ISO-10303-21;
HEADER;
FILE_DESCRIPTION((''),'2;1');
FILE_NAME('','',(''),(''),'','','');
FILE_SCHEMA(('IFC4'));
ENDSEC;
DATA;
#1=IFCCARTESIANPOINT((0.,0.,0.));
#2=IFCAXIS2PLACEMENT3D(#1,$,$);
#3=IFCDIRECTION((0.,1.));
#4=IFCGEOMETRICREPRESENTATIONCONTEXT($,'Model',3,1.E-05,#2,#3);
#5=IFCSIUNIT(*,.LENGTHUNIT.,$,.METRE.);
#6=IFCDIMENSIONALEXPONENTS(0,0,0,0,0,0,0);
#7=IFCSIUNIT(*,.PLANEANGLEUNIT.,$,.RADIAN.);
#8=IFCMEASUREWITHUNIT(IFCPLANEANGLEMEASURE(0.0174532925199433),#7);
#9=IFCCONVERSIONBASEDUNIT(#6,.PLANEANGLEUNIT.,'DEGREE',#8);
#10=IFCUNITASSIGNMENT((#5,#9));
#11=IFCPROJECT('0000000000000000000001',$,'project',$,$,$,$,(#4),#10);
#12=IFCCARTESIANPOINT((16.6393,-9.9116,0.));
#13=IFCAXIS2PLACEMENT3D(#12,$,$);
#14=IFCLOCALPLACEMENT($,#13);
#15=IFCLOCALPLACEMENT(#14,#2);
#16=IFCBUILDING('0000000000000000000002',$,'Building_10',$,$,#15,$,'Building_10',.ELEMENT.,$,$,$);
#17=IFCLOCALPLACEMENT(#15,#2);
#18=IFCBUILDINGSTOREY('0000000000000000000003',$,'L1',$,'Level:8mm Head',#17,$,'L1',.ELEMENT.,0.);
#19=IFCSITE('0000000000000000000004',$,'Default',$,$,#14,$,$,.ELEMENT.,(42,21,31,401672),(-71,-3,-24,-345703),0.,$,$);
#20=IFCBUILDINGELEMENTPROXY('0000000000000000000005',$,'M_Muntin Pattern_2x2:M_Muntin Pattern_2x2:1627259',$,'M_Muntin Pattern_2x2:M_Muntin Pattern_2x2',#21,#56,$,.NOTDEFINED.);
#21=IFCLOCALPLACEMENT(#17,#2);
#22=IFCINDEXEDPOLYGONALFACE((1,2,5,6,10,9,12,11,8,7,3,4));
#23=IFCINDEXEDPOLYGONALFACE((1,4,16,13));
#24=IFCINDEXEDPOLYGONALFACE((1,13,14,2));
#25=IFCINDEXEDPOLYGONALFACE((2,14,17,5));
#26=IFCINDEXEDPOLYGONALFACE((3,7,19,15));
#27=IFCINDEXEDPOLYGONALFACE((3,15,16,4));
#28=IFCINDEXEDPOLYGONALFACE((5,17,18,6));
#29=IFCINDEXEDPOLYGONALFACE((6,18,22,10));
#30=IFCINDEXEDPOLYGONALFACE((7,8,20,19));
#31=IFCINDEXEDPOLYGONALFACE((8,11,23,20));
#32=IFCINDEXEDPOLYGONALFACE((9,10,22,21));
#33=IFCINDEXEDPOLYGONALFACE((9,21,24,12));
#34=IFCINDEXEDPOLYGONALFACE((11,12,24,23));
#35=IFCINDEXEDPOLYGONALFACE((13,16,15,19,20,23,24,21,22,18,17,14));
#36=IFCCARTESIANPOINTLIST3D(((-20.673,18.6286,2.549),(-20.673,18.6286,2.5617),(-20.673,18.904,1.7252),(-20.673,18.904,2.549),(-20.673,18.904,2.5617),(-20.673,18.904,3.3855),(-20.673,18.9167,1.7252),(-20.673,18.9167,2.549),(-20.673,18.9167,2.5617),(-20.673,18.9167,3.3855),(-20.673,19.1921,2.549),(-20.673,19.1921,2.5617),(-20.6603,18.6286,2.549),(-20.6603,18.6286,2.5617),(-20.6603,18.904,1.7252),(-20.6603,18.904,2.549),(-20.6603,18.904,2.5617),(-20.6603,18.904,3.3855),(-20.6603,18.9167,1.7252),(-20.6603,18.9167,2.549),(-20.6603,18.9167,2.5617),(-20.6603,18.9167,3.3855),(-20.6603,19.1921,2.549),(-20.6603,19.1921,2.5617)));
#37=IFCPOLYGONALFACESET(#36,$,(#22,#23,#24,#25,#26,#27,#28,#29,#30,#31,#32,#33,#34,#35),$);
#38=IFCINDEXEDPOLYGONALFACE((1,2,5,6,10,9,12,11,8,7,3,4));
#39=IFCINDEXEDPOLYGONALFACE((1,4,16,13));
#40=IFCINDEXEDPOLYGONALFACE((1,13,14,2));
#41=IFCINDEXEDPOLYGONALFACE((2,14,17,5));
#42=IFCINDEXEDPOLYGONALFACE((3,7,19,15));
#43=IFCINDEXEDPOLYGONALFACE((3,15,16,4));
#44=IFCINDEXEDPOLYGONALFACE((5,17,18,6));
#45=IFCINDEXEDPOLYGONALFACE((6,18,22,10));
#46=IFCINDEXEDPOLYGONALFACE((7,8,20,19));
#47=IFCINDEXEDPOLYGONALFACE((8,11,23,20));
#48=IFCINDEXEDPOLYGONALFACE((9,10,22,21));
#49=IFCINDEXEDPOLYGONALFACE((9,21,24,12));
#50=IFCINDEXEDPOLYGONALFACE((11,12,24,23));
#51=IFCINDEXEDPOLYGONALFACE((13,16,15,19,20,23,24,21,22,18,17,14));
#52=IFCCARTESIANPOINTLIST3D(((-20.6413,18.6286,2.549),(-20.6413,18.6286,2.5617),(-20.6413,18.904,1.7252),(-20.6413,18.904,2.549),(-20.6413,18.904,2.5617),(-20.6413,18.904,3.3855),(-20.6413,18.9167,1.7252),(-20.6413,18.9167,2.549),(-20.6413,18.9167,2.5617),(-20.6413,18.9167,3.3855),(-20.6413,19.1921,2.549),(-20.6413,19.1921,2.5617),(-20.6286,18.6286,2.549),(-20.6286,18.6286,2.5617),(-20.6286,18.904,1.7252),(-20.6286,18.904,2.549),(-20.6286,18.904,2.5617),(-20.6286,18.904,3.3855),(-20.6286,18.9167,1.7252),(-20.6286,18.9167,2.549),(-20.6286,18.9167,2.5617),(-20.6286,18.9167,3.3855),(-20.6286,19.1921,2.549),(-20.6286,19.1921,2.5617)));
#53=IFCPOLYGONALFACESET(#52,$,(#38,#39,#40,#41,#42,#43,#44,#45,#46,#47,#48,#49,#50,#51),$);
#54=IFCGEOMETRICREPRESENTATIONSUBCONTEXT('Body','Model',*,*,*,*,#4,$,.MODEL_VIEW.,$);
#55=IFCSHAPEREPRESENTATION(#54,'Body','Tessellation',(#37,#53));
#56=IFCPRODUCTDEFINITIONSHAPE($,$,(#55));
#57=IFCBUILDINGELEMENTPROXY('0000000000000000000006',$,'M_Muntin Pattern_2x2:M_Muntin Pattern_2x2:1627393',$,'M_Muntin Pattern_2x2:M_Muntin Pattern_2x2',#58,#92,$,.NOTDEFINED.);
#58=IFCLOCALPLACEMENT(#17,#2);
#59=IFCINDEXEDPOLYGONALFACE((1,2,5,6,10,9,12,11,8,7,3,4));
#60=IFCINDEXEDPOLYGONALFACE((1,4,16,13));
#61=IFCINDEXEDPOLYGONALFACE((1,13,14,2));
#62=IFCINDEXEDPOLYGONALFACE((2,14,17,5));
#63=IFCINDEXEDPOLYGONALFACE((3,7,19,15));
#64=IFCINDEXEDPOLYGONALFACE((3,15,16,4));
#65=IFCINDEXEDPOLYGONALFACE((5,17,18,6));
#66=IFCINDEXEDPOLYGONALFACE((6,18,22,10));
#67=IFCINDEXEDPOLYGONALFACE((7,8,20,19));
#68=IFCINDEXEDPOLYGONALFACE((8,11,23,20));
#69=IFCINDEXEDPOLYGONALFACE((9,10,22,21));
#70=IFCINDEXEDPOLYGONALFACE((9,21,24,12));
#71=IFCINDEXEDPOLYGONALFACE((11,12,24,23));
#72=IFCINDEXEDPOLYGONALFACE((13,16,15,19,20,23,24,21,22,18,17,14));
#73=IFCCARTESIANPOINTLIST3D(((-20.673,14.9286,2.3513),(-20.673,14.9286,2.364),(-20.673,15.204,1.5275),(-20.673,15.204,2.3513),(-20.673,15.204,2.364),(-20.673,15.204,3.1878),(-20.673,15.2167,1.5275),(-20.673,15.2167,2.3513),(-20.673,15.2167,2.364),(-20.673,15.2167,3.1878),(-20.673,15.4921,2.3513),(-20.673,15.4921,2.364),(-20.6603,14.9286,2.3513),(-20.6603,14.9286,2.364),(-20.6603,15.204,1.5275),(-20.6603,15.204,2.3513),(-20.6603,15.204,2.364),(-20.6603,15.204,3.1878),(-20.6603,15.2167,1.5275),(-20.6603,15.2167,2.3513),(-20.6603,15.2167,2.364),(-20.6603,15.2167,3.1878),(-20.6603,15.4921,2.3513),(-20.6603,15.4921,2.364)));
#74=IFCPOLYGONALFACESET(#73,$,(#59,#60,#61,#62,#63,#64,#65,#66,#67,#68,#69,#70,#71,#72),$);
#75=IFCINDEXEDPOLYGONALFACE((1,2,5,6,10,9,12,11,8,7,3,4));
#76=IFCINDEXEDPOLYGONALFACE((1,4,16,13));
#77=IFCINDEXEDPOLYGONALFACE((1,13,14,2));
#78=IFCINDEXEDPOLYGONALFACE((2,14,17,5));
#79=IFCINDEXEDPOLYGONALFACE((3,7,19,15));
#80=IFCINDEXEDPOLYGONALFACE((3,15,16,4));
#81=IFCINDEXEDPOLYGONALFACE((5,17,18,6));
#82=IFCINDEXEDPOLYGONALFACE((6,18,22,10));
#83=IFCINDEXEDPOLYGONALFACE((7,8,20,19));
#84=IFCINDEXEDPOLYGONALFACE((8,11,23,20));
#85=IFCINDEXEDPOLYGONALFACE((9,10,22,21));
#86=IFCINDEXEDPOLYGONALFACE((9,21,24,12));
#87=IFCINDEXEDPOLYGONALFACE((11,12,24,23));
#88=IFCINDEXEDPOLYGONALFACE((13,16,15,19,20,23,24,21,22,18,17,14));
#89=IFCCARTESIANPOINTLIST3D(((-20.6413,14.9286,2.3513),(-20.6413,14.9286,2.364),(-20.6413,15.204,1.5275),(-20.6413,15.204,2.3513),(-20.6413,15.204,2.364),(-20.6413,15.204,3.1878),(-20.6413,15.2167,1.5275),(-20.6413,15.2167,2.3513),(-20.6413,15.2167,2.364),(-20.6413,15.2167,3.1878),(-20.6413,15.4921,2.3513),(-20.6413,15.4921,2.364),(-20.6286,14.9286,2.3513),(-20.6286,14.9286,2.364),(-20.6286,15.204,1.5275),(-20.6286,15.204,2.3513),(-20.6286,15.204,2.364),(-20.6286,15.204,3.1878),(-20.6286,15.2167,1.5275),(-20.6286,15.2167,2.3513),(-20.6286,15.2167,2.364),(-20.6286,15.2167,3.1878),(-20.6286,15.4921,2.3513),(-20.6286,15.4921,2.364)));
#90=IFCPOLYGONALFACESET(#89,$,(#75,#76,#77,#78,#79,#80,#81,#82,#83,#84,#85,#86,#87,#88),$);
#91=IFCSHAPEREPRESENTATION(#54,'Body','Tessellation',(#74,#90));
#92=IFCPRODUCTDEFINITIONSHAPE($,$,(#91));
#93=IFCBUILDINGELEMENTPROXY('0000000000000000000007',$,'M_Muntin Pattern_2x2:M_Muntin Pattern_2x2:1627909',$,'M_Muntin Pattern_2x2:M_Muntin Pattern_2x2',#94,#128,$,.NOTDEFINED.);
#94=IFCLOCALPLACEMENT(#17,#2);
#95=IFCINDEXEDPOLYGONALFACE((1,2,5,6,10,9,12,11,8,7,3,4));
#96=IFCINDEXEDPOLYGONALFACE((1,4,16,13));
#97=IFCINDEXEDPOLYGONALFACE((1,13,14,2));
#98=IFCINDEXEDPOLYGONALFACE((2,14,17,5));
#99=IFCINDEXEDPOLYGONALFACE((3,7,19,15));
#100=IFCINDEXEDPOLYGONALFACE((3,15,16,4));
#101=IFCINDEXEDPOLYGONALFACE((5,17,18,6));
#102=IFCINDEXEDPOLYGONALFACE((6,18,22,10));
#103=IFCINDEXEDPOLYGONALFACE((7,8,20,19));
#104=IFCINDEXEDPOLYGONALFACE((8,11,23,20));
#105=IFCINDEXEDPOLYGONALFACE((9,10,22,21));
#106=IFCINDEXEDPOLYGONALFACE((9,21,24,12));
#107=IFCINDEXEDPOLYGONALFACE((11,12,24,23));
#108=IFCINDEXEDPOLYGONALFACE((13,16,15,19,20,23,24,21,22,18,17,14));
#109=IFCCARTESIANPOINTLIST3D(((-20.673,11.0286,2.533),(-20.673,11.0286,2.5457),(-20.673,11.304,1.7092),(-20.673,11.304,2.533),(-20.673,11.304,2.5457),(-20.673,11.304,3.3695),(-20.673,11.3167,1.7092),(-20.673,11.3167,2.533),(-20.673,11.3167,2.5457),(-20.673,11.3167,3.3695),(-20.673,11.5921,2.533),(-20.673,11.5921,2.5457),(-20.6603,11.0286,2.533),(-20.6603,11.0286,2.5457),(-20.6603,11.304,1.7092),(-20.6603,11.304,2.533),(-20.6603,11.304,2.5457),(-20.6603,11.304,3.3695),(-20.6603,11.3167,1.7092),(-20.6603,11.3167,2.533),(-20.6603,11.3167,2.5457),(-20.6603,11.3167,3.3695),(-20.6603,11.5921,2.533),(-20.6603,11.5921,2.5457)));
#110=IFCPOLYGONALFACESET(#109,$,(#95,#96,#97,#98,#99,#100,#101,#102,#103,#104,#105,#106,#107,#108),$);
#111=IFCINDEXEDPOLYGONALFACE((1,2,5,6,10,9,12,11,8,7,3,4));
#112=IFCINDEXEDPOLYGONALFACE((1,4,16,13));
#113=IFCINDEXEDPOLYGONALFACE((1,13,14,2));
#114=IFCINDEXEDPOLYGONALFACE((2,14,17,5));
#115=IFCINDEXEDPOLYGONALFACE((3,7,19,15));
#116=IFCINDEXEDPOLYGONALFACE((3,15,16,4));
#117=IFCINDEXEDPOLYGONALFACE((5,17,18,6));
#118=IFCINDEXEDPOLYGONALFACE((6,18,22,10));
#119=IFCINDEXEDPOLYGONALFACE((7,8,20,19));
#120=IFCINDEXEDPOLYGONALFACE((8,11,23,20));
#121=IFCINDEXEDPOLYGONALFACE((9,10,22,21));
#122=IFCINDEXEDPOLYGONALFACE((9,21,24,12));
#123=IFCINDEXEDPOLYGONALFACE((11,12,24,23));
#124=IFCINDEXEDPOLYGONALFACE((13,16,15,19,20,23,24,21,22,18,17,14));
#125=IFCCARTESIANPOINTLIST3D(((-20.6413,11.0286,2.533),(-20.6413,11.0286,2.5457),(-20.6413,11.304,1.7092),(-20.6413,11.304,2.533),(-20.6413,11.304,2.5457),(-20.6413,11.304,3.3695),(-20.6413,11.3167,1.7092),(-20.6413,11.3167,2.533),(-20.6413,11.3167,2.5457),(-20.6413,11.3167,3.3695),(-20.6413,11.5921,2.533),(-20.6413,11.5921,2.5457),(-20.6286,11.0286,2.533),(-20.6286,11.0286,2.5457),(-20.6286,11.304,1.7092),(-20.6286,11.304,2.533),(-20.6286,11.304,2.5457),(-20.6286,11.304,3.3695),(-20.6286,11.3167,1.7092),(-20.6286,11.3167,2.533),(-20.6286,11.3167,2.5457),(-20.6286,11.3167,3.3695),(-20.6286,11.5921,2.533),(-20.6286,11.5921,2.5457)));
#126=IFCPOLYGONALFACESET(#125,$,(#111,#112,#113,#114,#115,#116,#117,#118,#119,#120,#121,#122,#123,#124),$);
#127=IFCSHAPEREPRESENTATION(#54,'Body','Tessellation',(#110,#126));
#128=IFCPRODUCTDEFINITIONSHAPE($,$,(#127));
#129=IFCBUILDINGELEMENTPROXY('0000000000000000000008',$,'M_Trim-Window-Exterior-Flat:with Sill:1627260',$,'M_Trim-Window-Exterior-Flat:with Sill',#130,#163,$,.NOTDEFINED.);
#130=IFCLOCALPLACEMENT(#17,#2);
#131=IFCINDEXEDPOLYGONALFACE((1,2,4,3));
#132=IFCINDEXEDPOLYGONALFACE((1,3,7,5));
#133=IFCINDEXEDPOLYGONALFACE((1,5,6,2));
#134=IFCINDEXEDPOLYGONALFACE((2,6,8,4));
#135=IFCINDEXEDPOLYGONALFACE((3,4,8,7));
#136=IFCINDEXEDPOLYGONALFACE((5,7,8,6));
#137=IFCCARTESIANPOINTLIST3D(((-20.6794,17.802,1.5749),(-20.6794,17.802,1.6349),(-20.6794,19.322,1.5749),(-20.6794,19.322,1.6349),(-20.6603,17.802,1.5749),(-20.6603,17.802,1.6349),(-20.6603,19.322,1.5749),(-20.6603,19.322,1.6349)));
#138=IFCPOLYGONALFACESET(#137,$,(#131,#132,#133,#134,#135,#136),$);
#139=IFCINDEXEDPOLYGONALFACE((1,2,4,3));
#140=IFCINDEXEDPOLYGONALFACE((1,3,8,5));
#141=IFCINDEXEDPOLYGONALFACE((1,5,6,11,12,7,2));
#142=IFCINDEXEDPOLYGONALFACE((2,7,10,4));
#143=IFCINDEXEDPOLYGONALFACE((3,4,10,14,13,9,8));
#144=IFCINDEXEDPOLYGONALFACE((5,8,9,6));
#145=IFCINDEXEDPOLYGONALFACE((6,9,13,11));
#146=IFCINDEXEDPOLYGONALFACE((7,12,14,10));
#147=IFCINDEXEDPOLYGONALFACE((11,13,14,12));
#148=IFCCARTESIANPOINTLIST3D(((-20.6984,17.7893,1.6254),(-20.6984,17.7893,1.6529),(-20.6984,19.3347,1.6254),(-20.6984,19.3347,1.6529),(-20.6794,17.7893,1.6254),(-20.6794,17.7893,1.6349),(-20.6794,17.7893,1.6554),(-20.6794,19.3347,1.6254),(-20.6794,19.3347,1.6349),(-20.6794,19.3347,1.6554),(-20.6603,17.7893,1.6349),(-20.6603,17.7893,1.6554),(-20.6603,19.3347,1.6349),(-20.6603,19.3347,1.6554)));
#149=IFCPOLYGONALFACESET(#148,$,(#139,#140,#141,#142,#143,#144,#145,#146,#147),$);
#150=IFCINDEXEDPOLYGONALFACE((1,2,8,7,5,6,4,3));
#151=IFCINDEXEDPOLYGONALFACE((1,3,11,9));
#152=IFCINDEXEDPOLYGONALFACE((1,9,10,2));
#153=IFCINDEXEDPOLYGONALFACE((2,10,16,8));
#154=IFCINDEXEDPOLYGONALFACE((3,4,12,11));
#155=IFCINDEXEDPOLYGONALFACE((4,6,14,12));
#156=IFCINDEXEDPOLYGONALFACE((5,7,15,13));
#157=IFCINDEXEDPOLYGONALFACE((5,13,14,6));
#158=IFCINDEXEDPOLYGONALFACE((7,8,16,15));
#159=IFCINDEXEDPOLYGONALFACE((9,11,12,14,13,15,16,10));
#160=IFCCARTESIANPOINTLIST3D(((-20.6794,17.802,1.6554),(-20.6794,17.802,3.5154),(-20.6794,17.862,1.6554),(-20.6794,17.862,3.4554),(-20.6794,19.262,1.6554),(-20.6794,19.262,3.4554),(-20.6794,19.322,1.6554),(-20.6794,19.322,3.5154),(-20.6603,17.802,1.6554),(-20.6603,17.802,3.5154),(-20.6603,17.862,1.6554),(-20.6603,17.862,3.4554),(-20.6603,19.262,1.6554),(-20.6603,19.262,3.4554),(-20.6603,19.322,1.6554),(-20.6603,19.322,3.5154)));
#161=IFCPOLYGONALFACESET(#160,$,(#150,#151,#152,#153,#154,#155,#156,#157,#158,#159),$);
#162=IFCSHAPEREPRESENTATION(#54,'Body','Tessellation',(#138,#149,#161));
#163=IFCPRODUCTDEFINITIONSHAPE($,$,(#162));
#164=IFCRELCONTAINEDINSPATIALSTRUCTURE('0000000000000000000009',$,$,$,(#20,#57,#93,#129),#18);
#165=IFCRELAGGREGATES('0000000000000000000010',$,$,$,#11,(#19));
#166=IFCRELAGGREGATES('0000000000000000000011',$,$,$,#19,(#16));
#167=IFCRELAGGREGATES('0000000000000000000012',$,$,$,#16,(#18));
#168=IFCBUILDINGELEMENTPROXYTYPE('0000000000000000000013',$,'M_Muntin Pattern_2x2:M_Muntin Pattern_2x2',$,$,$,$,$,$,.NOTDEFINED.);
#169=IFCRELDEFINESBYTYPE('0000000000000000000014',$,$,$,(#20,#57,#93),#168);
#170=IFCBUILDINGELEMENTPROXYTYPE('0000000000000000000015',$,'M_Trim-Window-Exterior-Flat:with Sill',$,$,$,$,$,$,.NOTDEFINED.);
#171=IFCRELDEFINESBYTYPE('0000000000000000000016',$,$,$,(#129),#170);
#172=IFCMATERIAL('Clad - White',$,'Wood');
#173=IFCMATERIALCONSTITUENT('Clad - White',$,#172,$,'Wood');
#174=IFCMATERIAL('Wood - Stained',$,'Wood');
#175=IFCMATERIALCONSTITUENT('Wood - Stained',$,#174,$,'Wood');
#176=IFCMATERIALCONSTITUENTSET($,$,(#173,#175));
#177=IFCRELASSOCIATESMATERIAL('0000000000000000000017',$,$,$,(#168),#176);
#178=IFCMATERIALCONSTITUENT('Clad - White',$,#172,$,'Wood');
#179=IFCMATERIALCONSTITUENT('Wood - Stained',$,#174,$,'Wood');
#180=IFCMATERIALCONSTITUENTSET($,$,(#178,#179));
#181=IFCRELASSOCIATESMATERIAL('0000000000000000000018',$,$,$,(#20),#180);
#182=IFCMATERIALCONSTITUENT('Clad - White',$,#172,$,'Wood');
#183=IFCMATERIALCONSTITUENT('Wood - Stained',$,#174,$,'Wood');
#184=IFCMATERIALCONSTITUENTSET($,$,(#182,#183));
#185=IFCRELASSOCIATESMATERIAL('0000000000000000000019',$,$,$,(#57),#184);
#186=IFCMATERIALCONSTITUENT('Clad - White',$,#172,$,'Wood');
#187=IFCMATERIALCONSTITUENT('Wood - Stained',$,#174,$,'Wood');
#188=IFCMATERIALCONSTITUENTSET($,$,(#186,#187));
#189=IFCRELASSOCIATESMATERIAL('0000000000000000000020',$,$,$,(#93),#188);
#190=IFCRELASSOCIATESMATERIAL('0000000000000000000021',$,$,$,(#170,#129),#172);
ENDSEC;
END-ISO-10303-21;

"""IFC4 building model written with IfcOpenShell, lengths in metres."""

from ifc_helpers import new_model, entity, si_unit, converted_unit, direction, frame, origin, place, context, subcontext, project, spatial, indexed_curve, outline, extrude, source, transform, mapped, material, constituent, constituent_set, type_object, type_shapes, element, save


model = new_model("IFC4")

# Units and contexts
model_context = context("Model", 3, precision=1e-05, world=origin(), true_north=direction((0.0, 1.0)))
body_context = subcontext(model_context, "Body", "Model", "MODEL_VIEW")
ifc_project = project(units=[si_unit("LENGTHUNIT", "METRE"), converted_unit("PLANEANGLEUNIT", "DEGREE", entity("IfcPlaneAngleMeasure", 0.0174532925199433), si_unit("PLANEANGLEUNIT", "RADIAN"), dimensions=[0, 0, 0, 0, 0, 0, 0])], contexts=[model_context])

# Site, building, storey
site_placement = place(None, frame((16.6393, -9.9116, 0.0)))
site = spatial("IfcSite", under=ifc_project, at=site_placement, Name="Default", CompositionType="ELEMENT", RefLatitude=(42, 21, 31, 401672), RefLongitude=(-71, -3, -24, -345703), RefElevation=0.0)
building_placement = place(site_placement, origin())
building = spatial("IfcBuilding", under=site, at=building_placement, Name="Building_10", LongName="Building_10", CompositionType="ELEMENT")
storey_placement = place(building_placement, origin())
storey = spatial("IfcBuildingStorey", under=building, at=storey_placement, Name="L1", ObjectType="Level:8mm Head", LongName="L1", CompositionType="ELEMENT", Elevation=0.0)

# Building element proxies
ifc_material_1 = material(Name="Clad - White", Category="Wood")
ifc_material_2 = material(Name="Wood - Stained", Category="Wood")
ifc_constituent_1 = constituent(ifc_material_1, Name="Clad - White", Category="Wood")
ifc_constituent_2 = constituent(ifc_material_2, Name="Wood - Stained", Category="Wood")
ifc_constituent_set_1 = constituent_set(constituents=[ifc_constituent_1, ifc_constituent_2])
ifc_constituent_3 = constituent(ifc_material_1, Name="Clad - White", Category="Wood")
ifc_constituent_4 = constituent(ifc_material_2, Name="Wood - Stained", Category="Wood")
ifc_constituent_set_2 = constituent_set(constituents=[ifc_constituent_3, ifc_constituent_4])
building_element_proxy_type_1 = type_object("IfcBuildingElementProxyType", Name="M_Muntin Pattern_2x2:M_Muntin Pattern_2x2", PredefinedType="NOTDEFINED", material=ifc_constituent_set_2)
shared_shape_1 = source(origin(), body_context, "Body", "SweptSolid", [
    extrude(outline(indexed_curve([(0.0064, -0.0064), (0.8301, -0.0064), (0.8301, 0.0063), (0.0064, 0.0063), (0.0064, 0.2817), (-0.0063, 0.2817), (-0.0063, 0.0063), (-0.8302, 0.0063), (-0.8302, -0.0064), (-0.0063, -0.0064), (-0.0063, -0.2817), (0.0064, -0.2817), (0.0064, -0.0064)], self_intersect=False)), frame((0.0, -0.0222, 0.8301), z_axis=(0.0, 1.0, 0.0), x_axis=(0.0, 0.0, 1.0)), (0.0, 0.0, 1.0), 0.0127),
    extrude(outline(indexed_curve([(0.0064, -0.0064), (0.8302, -0.0064), (0.8302, 0.0063), (0.0064, 0.0063), (0.0064, 0.2817), (-0.0063, 0.2817), (-0.0063, 0.0063), (-0.8302, 0.0063), (-0.8302, -0.0064), (-0.0063, -0.0064), (-0.0063, -0.2817), (0.0064, -0.2817), (0.0064, -0.0064)], self_intersect=False)), frame((0.0, 0.0095, 0.8302), z_axis=(0.0, 1.0, 0.0), x_axis=(0.0, 0.0, 1.0)), (0.0, 0.0, 1.0), 0.0127),
])
type_shapes(building_element_proxy_type_1, [shared_shape_1])
proxy_1_placement = place(storey_placement, frame((-20.6508, 18.9104, 1.7252), z_axis=(0.0, 0.0, 1.0), x_axis=(0.0, -1.0, 0.0)))
element("IfcBuildingElementProxy", 1, at=proxy_1_placement, inside=storey, type_object=building_element_proxy_type_1, material=ifc_constituent_set_1, Name="M_Muntin Pattern_2x2:M_Muntin Pattern_2x2:1627259", ObjectType="M_Muntin Pattern_2x2:M_Muntin Pattern_2x2", PredefinedType="NOTDEFINED", context=body_context, shape_type="MappedRepresentation", body=[
    mapped(shared_shape_1, transform((0.0, 0.0, 0.0), scale=1.0)),
])
ifc_constituent_5 = constituent(ifc_material_1, Name="Clad - White", Category="Wood")
ifc_constituent_6 = constituent(ifc_material_2, Name="Wood - Stained", Category="Wood")
ifc_constituent_set_3 = constituent_set(constituents=[ifc_constituent_5, ifc_constituent_6])
proxy_2_placement = place(storey_placement, frame((-20.6508, 15.2104, 1.5275), z_axis=(0.0, 0.0, 1.0), x_axis=(0.0, -1.0, 0.0)))
element("IfcBuildingElementProxy", 2, at=proxy_2_placement, inside=storey, type_object=building_element_proxy_type_1, material=ifc_constituent_set_3, Name="M_Muntin Pattern_2x2:M_Muntin Pattern_2x2:1627393", ObjectType="M_Muntin Pattern_2x2:M_Muntin Pattern_2x2", PredefinedType="NOTDEFINED", context=body_context, shape_type="MappedRepresentation", body=[
    mapped(shared_shape_1, transform((0.0, 0.0, 0.0), scale=1.0)),
])
ifc_constituent_7 = constituent(ifc_material_1, Name="Clad - White", Category="Wood")
ifc_constituent_8 = constituent(ifc_material_2, Name="Wood - Stained", Category="Wood")
ifc_constituent_set_4 = constituent_set(constituents=[ifc_constituent_7, ifc_constituent_8])
proxy_3_placement = place(storey_placement, frame((-20.6508, 11.3104, 1.7092), z_axis=(0.0, 0.0, 1.0), x_axis=(0.0, -1.0, 0.0)))
element("IfcBuildingElementProxy", 3, at=proxy_3_placement, inside=storey, type_object=building_element_proxy_type_1, material=ifc_constituent_set_4, Name="M_Muntin Pattern_2x2:M_Muntin Pattern_2x2:1627909", ObjectType="M_Muntin Pattern_2x2:M_Muntin Pattern_2x2", PredefinedType="NOTDEFINED", context=body_context, shape_type="MappedRepresentation", body=[
    mapped(shared_shape_1, transform((0.0, 0.0, 0.0), scale=1.0)),
])
building_element_proxy_type_2 = type_object("IfcBuildingElementProxyType", Name="M_Trim-Window-Exterior-Flat:with Sill", PredefinedType="NOTDEFINED", material=ifc_material_1)
shared_shape_2 = source(origin(), body_context, "Body", "SweptSolid", [
    extrude(outline(indexed_curve([(-0.76, -0.03), (0.76, -0.03), (0.76, 0.03), (-0.76, 0.03), (-0.76, -0.03)], self_intersect=False)), frame((0.0, -1.8504, 0.0), z_axis=(0.0, 0.0, 1.0), x_axis=(-1.0, 0.0, 0.0)), (0.0, 0.0, 1.0), 0.0191),
    extrude(outline(indexed_curve([(-0.019, -0.0152), (0.0, -0.0152), (0.0, -0.0057), (0.019, -0.0057), (0.019, 0.0148), (0.0, 0.0148), (-0.019, 0.0123), (-0.019, -0.0152)], self_intersect=False)), frame((-0.7727, -1.8148, 0.019), z_axis=(1.0, 0.0, 0.0), x_axis=(0.0, 0.0, -1.0)), (0.0, 0.0, 1.0), 1.5454),
    extrude(outline(indexed_curve([(-0.945, -0.76), (0.915, -0.76), (0.915, -0.7), (-0.885, -0.7), (-0.885, 0.7), (0.915, 0.7), (0.915, 0.76), (-0.945, 0.76), (-0.945, -0.76)], self_intersect=False)), frame((0.0, -0.885, 0.0), z_axis=(0.0, 0.0, 1.0), x_axis=(0.0, -1.0, 0.0)), (0.0, 0.0, 1.0), 0.0191),
])
type_shapes(building_element_proxy_type_2, [shared_shape_2])
for number, where, z_axis, x_axis, name in (
    (4, (-20.6603, 18.562, 3.4554), (-1.0, 0.0, 0.0), (0.0, -1.0, 0.0), "M_Trim-Window-Exterior-Flat:with Sill:1627260"),
):
    element("IfcBuildingElementProxy", number, at=place(storey_placement, frame(where, z_axis=z_axis, x_axis=x_axis)), inside=storey, type_object=building_element_proxy_type_2, material=ifc_material_1, Name=name, ObjectType="M_Trim-Window-Exterior-Flat:with Sill", PredefinedType="NOTDEFINED", context=body_context, shape_type="MappedRepresentation", body=[
        mapped(shared_shape_2, transform((0.0, 0.0, 0.0), scale=1.0)),
    ])

save(model, "model.ifc")
